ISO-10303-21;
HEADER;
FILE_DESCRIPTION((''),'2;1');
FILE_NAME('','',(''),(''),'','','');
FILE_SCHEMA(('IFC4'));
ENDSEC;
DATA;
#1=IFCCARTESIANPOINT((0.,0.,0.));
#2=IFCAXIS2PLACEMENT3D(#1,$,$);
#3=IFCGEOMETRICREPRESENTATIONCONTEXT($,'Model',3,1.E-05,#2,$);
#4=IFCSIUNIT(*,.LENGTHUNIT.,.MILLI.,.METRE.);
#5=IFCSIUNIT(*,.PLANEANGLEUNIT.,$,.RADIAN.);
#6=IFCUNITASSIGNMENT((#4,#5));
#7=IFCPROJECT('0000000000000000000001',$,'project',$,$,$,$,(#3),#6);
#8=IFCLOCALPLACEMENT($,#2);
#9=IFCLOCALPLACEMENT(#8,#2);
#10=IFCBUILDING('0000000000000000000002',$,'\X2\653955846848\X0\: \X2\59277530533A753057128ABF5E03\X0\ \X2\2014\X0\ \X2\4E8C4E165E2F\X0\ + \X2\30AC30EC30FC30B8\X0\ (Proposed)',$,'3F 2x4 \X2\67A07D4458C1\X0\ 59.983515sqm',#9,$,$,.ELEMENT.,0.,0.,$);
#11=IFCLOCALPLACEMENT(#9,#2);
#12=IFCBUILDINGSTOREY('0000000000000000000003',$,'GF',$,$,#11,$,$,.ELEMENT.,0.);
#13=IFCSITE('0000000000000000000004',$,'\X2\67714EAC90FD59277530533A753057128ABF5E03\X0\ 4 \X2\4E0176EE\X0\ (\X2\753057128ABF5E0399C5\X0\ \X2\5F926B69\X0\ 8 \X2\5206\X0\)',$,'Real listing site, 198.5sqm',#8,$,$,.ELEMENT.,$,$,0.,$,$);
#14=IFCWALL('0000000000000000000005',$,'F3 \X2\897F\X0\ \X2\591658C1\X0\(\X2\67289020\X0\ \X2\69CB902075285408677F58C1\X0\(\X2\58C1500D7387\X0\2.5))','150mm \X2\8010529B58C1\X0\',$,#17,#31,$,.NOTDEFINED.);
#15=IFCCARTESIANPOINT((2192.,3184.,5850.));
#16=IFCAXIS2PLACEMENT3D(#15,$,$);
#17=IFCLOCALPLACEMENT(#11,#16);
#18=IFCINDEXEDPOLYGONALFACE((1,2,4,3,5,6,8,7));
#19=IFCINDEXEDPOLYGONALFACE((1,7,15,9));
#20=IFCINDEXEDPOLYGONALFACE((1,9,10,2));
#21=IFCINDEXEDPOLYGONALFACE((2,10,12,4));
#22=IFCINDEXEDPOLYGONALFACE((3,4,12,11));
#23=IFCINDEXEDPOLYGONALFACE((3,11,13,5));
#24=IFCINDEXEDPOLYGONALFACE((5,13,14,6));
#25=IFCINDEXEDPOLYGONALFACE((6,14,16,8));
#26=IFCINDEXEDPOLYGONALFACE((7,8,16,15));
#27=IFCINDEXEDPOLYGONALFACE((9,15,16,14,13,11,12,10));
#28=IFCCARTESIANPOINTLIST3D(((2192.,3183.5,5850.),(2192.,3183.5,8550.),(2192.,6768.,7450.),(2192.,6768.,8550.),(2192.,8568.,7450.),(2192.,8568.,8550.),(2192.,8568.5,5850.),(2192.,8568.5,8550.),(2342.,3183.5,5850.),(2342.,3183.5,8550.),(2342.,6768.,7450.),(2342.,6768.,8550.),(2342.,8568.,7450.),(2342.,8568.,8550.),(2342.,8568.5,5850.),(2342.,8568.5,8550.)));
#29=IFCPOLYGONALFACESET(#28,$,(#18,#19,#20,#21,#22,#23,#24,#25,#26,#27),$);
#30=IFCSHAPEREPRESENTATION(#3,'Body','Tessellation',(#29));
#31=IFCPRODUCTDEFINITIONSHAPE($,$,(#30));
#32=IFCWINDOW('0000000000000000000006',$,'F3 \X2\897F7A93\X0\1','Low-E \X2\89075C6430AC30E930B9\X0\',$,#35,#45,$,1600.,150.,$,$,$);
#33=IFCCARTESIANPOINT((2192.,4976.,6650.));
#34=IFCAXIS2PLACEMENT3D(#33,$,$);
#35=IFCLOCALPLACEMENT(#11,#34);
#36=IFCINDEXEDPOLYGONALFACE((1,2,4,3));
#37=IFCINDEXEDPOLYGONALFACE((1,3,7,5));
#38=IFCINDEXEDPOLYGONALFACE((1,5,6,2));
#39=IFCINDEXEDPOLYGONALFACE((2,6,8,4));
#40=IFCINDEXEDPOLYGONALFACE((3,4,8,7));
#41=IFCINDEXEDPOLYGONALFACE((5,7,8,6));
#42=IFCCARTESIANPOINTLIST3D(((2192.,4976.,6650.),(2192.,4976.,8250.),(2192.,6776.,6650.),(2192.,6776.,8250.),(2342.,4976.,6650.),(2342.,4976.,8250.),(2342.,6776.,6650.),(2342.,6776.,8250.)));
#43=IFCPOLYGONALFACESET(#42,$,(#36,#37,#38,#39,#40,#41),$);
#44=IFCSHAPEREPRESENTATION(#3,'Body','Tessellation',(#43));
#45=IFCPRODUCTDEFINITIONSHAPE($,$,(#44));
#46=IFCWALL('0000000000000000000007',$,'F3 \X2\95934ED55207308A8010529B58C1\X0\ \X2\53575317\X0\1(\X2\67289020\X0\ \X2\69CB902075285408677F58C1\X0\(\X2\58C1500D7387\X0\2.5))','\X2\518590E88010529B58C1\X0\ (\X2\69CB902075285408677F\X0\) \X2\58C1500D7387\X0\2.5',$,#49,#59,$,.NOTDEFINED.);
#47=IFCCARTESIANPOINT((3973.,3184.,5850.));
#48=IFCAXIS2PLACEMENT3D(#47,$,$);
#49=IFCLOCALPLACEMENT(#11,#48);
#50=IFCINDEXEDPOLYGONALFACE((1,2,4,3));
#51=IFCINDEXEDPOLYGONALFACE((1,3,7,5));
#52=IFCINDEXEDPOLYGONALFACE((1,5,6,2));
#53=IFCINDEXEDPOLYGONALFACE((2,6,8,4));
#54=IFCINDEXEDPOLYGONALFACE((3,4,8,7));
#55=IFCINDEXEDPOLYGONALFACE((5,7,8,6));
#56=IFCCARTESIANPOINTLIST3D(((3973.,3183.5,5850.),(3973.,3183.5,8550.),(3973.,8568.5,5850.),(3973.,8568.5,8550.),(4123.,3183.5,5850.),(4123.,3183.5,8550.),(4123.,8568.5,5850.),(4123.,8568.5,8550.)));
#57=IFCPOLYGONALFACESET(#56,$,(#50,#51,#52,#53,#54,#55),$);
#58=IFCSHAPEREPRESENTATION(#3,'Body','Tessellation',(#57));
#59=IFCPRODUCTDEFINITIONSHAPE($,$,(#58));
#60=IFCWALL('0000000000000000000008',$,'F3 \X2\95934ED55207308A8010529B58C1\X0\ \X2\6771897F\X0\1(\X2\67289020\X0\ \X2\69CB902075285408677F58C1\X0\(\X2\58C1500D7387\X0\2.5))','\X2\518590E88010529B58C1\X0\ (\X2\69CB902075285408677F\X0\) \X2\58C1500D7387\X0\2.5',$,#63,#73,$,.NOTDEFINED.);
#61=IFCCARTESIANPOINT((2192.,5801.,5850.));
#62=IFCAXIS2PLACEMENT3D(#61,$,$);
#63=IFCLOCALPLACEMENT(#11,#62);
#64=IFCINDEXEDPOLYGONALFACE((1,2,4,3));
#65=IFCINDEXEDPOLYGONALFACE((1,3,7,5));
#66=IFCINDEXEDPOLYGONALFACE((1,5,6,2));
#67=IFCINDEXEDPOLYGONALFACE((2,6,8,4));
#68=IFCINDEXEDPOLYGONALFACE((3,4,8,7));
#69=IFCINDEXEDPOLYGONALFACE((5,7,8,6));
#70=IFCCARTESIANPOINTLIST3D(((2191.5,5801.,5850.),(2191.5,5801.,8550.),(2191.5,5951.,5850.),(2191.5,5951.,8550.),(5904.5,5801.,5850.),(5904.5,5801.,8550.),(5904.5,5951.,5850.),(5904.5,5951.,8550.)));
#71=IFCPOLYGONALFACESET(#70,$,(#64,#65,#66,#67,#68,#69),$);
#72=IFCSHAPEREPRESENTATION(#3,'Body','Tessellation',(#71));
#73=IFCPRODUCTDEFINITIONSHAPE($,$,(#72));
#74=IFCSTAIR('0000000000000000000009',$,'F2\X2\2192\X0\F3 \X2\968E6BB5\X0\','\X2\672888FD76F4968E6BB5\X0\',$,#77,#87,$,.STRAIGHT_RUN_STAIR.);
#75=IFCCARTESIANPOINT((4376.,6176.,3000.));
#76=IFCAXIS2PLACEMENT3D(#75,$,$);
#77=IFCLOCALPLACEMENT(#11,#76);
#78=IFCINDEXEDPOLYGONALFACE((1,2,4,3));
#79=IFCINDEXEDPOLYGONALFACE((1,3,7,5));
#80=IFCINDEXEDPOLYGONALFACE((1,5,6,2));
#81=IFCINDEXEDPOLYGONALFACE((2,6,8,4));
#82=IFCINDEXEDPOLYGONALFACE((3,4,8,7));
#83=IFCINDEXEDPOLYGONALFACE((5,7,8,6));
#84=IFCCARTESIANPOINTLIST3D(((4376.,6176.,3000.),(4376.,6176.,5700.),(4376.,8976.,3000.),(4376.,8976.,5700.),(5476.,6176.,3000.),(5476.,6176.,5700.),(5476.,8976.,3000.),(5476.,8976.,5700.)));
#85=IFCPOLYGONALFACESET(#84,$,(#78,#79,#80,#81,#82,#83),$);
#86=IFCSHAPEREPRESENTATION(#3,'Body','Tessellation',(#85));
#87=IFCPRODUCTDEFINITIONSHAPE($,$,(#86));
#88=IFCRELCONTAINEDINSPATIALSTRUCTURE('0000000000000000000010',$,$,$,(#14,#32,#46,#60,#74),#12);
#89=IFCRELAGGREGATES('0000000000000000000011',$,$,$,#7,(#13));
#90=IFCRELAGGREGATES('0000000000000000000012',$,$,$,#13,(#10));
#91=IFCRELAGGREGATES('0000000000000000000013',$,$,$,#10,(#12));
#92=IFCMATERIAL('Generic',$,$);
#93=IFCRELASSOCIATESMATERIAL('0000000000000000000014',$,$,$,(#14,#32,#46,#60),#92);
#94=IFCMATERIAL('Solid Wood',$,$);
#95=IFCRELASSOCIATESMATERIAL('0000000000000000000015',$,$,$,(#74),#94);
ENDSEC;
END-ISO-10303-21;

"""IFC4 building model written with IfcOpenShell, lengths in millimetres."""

from ifc_helpers import new_model, si_unit, frame, frame_2d, origin, place, context, project, spatial, rectangle, extrude, material, element, fill, save


model = new_model("IFC4")

# Units and contexts
model_context = context("Model", 3, precision=1e-05, world=origin())
ifc_project = project(units=[si_unit("LENGTHUNIT", "METRE", prefix="MILLI"), si_unit("PLANEANGLEUNIT", "RADIAN")], contexts=[model_context])

# Site, building, storey
site_placement = place(None, origin())
site = spatial("IfcSite", under=ifc_project, at=site_placement, Name="東京都大田区田園調布 4 丁目 (田園調布駅 徒歩 8 分)", ObjectType="Real listing site, 198.5sqm", CompositionType="ELEMENT", RefElevation=0.0)
building_placement = place(site_placement, origin())
building = spatial("IfcBuilding", under=site, at=building_placement, Name="改善案: 大田区田園調布 — 二世帯 + ガレージ (Proposed)", ObjectType="3F 2x4 枠組壁 59.983515sqm", CompositionType="ELEMENT", ElevationOfRefHeight=0.0, ElevationOfTerrain=0.0)
storey_placement = place(building_placement, origin())
storey = spatial("IfcBuildingStorey", under=building, at=storey_placement, Name="GF", CompositionType="ELEMENT", Elevation=0.0)

# Shared definitions
ifc_material_1 = material(Name="Generic")

# Wall, opening, window
wall_1_placement = place(storey_placement, frame((2192.0, 3184.0, 5850.0)))
wall_1 = element("IfcWall", 1, at=wall_1_placement, inside=storey, material=ifc_material_1, Name="F3 西 外壁(木造 構造用合板壁(壁倍率2.5))", Description="150mm 耐力壁", PredefinedType="NOTDEFINED", context=model_context, shape_type="SweptSolid", body=[
    extrude(rectangle(XDim=150.0, YDim=5385.0, at=frame_2d((75.0, 2692.0))), frame((2192.0, 3184.0, 5850.0)), (0.0, 0.0, 1.0), 2700.0),
])
opening_1_placement = place(storey_placement, frame((2192.0, 4976.0, 6650.0)))
opening_1 = element("IfcOpeningElement", 2, at=opening_1_placement, cuts=wall_1, PredefinedType="NOTDEFINED", context=model_context, shape_type="SweptSolid", body=[
    extrude(rectangle(XDim=150.0, YDim=1800.0, at=frame_2d((75.0, 900.0))), frame((2192.0, 4976.0, 6650.0)), (0.0, 0.0, 1.0), 1600.0),
])
window_1_placement = place(storey_placement, frame((2192.0, 4976.0, 6650.0)))
window_1 = element("IfcWindow", 3, at=window_1_placement, inside=storey, material=ifc_material_1, Name="F3 西窓1", Description="Low-E 複層ガラス", OverallHeight=1600.0, OverallWidth=150.0, context=model_context, shape_type="SweptSolid", body=[
    extrude(rectangle(XDim=150.0, YDim=1800.0, at=frame_2d((75.0, 900.0))), frame((2192.0, 4976.0, 6650.0)), (0.0, 0.0, 1.0), 1600.0),
])
fill(opening_1, window_1)

# Walls
wall_2_placement = place(storey_placement, frame((3973.0, 3184.0, 5850.0)))
element("IfcWall", 4, at=wall_2_placement, inside=storey, material=ifc_material_1, Name="F3 間仕切り耐力壁 南北1(木造 構造用合板壁(壁倍率2.5))", Description="内部耐力壁 (構造用合板) 壁倍率2.5", PredefinedType="NOTDEFINED", context=model_context, shape_type="SweptSolid", body=[
    extrude(rectangle(XDim=150.0, YDim=5385.0, at=frame_2d((75.0, 2692.0))), frame((3973.0, 3184.0, 5850.0)), (0.0, 0.0, 1.0), 2700.0),
])
wall_3_placement = place(storey_placement, frame((2192.0, 5801.0, 5850.0)))
element("IfcWall", 5, at=wall_3_placement, inside=storey, material=ifc_material_1, Name="F3 間仕切り耐力壁 東西1(木造 構造用合板壁(壁倍率2.5))", Description="内部耐力壁 (構造用合板) 壁倍率2.5", PredefinedType="NOTDEFINED", context=model_context, shape_type="SweptSolid", body=[
    extrude(rectangle(XDim=3713.0, YDim=150.0, at=frame_2d((1856.0, 75.0))), frame((2192.0, 5801.0, 5850.0)), (0.0, 0.0, 1.0), 2700.0),
])

# Stair
ifc_material_2 = material(Name="Solid Wood")
stair_placement = place(storey_placement, frame((4376.0, 6176.0, 3000.0)))
element("IfcStair", 6, at=stair_placement, inside=storey, material=ifc_material_2, Name="F2→F3 階段", Description="木製直階段", PredefinedType="STRAIGHT_RUN_STAIR", context=model_context, shape_type="SweptSolid", body=[
    extrude(rectangle(XDim=1100.0, YDim=2800.0, at=frame_2d((550.0, 1400.0))), frame((4376.0, 6176.0, 3000.0)), (0.0, 0.0, 1.0), 2700.0),
])

save(model, "model.ifc")
